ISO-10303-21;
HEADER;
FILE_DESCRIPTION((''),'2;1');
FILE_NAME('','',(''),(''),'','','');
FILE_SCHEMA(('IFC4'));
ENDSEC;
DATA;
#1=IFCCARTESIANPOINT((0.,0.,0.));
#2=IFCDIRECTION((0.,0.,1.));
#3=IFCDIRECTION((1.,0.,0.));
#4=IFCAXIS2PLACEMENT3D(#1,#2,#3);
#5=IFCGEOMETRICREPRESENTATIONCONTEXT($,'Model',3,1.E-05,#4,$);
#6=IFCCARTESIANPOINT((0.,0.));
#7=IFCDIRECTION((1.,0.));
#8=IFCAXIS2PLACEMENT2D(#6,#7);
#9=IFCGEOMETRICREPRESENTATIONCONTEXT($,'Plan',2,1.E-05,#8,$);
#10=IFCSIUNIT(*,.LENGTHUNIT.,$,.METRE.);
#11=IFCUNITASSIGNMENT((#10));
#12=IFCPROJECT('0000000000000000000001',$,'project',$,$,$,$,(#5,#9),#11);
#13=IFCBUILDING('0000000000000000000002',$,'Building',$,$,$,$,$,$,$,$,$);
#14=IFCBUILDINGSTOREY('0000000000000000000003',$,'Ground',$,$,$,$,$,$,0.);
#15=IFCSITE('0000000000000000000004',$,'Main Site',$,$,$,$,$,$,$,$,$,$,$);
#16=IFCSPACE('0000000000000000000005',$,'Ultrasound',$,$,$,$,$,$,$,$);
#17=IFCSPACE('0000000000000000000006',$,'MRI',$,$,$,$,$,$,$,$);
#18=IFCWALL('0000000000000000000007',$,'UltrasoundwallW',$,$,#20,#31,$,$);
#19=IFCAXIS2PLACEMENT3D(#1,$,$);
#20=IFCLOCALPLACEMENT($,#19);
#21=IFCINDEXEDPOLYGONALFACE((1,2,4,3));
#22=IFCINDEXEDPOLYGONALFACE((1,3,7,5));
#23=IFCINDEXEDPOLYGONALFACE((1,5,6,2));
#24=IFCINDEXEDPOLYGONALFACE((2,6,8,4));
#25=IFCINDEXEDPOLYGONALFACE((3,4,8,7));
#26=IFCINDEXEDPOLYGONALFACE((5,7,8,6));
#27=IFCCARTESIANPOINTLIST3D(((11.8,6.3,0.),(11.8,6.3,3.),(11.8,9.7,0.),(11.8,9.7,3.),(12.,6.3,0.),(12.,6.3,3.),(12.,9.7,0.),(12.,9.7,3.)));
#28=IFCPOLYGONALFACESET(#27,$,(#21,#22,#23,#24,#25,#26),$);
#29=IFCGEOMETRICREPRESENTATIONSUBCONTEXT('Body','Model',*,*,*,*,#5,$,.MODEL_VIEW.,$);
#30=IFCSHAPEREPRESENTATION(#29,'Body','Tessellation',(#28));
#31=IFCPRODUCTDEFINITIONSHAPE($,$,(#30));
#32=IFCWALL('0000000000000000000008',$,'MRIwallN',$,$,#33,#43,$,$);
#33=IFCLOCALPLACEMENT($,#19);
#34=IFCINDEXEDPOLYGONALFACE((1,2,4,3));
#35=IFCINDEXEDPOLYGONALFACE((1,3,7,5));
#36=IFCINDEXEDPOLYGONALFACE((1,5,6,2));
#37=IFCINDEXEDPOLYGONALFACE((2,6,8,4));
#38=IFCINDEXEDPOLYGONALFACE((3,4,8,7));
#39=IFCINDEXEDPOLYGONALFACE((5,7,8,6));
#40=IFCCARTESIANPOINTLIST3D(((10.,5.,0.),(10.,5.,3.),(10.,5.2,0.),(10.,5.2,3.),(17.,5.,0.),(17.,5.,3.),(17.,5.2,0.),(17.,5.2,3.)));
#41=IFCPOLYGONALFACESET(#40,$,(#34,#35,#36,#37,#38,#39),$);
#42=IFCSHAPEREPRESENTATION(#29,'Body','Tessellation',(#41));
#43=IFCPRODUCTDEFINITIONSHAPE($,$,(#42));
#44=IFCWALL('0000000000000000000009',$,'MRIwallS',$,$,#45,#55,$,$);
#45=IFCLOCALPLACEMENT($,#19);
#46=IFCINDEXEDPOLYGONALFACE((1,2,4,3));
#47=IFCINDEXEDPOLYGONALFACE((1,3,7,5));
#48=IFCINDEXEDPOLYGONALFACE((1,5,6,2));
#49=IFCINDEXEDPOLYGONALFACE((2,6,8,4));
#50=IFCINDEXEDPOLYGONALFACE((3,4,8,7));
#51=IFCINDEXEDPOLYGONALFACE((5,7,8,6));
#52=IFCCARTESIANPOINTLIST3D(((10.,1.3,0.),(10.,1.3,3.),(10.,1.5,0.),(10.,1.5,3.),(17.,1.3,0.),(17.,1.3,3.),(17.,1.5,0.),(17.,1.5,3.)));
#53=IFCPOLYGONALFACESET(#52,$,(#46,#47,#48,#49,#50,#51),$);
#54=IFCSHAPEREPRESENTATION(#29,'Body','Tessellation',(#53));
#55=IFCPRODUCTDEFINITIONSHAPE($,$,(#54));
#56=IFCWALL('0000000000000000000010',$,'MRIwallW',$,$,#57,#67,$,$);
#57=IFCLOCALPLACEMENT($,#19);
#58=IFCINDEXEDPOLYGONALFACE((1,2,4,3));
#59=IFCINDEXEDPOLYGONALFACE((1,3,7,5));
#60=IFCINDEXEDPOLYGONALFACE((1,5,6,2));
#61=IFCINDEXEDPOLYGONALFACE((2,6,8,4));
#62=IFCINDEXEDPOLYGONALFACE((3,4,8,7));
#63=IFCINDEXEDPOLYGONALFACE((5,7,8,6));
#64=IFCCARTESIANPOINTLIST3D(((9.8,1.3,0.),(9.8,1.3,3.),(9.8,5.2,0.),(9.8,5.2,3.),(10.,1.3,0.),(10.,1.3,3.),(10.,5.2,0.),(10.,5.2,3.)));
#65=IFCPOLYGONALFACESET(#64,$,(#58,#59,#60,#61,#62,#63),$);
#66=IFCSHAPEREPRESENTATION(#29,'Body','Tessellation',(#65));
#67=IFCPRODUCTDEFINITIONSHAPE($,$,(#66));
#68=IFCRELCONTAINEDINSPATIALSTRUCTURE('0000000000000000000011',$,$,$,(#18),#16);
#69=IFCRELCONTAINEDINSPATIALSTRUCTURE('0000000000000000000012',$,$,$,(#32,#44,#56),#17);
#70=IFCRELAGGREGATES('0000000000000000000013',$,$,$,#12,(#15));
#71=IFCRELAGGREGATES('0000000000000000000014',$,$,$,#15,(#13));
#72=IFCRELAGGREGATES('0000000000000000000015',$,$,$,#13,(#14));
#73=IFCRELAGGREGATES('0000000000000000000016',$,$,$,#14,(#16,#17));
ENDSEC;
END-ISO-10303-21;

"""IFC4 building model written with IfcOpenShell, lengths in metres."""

from ifc_helpers import new_model, si_unit, frame, origin_with_axes, origin_2d_with_axis, place, context, subcontext, project, spatial, indexed_curve, outline, extrude, element, save


model = new_model("IFC4")

# Units and contexts
model_context = context("Model", 3, precision=1e-05, world=origin_with_axes())
plan_context = context("Plan", 2, precision=1e-05, world=origin_2d_with_axis())
body_context = subcontext(model_context, "Body", "Model", "MODEL_VIEW")
ifc_project = project(units=[si_unit("LENGTHUNIT", "METRE")], contexts=[model_context, plan_context])

# Site, building, storey
site = spatial("IfcSite", under=ifc_project, Name="Main Site")
building = spatial("IfcBuilding", under=site, Name="Building")
storey = spatial("IfcBuildingStorey", under=building, Name="Ground", Elevation=0.0)

# Shared definitions
space_1 = spatial("IfcSpace", under=storey, Name="Ultrasound")

# Wall
wall_1_placement = place(None, frame((12.0, 6.3, 0.0), z_axis=(0.0, 0.0, 1.0), x_axis=(0.0, 1.0, 0.0)))
element("IfcWall", 1, at=wall_1_placement, inside=space_1, Name="UltrasoundwallW", context=body_context, shape_type="SweptSolid", body=[
    extrude(outline(indexed_curve([(0.0, 0.0), (0.0, 0.2), (3.4, 0.2), (3.4, 0.0), (0.0, 0.0)], self_intersect=False)), origin_with_axes(), (0.0, 0.0, 1.0), 3.0),
])

# Shared definitions
space_2 = spatial("IfcSpace", under=storey, Name="MRI")

# Walls
for number, where, z_axis, x_axis, name in (
    (2, (10.0, 5.0, 0.0), (0.0, 0.0, 1.0), (1.0, 0.0, 0.0), "MRIwallN"),
    (3, (10.0, 1.3, 0.0), (0.0, 0.0, 1.0), (1.0, 0.0, 0.0), "MRIwallS"),
):
    element("IfcWall", number, at=place(None, frame(where, z_axis=z_axis, x_axis=x_axis)), inside=space_2, Name=name, context=body_context, shape_type="SweptSolid", body=[
        extrude(outline(indexed_curve([(0.0, 0.0), (0.0, 0.2), (7.0, 0.2), (7.0, 0.0), (0.0, 0.0)], self_intersect=False)), origin_with_axes(), (0.0, 0.0, 1.0), 3.0),
    ])
wall_2_placement = place(None, frame((10.0, 1.3, 0.0), z_axis=(0.0, 0.0, 1.0), x_axis=(0.0, 1.0, 0.0)))
element("IfcWall", 4, at=wall_2_placement, inside=space_2, Name="MRIwallW", context=body_context, shape_type="SweptSolid", body=[
    extrude(outline(indexed_curve([(0.0, 0.0), (0.0, 0.2), (3.9, 0.2), (3.9, 0.0), (0.0, 0.0)], self_intersect=False)), origin_with_axes(), (0.0, 0.0, 1.0), 3.0),
])

save(model, "model.ifc")
